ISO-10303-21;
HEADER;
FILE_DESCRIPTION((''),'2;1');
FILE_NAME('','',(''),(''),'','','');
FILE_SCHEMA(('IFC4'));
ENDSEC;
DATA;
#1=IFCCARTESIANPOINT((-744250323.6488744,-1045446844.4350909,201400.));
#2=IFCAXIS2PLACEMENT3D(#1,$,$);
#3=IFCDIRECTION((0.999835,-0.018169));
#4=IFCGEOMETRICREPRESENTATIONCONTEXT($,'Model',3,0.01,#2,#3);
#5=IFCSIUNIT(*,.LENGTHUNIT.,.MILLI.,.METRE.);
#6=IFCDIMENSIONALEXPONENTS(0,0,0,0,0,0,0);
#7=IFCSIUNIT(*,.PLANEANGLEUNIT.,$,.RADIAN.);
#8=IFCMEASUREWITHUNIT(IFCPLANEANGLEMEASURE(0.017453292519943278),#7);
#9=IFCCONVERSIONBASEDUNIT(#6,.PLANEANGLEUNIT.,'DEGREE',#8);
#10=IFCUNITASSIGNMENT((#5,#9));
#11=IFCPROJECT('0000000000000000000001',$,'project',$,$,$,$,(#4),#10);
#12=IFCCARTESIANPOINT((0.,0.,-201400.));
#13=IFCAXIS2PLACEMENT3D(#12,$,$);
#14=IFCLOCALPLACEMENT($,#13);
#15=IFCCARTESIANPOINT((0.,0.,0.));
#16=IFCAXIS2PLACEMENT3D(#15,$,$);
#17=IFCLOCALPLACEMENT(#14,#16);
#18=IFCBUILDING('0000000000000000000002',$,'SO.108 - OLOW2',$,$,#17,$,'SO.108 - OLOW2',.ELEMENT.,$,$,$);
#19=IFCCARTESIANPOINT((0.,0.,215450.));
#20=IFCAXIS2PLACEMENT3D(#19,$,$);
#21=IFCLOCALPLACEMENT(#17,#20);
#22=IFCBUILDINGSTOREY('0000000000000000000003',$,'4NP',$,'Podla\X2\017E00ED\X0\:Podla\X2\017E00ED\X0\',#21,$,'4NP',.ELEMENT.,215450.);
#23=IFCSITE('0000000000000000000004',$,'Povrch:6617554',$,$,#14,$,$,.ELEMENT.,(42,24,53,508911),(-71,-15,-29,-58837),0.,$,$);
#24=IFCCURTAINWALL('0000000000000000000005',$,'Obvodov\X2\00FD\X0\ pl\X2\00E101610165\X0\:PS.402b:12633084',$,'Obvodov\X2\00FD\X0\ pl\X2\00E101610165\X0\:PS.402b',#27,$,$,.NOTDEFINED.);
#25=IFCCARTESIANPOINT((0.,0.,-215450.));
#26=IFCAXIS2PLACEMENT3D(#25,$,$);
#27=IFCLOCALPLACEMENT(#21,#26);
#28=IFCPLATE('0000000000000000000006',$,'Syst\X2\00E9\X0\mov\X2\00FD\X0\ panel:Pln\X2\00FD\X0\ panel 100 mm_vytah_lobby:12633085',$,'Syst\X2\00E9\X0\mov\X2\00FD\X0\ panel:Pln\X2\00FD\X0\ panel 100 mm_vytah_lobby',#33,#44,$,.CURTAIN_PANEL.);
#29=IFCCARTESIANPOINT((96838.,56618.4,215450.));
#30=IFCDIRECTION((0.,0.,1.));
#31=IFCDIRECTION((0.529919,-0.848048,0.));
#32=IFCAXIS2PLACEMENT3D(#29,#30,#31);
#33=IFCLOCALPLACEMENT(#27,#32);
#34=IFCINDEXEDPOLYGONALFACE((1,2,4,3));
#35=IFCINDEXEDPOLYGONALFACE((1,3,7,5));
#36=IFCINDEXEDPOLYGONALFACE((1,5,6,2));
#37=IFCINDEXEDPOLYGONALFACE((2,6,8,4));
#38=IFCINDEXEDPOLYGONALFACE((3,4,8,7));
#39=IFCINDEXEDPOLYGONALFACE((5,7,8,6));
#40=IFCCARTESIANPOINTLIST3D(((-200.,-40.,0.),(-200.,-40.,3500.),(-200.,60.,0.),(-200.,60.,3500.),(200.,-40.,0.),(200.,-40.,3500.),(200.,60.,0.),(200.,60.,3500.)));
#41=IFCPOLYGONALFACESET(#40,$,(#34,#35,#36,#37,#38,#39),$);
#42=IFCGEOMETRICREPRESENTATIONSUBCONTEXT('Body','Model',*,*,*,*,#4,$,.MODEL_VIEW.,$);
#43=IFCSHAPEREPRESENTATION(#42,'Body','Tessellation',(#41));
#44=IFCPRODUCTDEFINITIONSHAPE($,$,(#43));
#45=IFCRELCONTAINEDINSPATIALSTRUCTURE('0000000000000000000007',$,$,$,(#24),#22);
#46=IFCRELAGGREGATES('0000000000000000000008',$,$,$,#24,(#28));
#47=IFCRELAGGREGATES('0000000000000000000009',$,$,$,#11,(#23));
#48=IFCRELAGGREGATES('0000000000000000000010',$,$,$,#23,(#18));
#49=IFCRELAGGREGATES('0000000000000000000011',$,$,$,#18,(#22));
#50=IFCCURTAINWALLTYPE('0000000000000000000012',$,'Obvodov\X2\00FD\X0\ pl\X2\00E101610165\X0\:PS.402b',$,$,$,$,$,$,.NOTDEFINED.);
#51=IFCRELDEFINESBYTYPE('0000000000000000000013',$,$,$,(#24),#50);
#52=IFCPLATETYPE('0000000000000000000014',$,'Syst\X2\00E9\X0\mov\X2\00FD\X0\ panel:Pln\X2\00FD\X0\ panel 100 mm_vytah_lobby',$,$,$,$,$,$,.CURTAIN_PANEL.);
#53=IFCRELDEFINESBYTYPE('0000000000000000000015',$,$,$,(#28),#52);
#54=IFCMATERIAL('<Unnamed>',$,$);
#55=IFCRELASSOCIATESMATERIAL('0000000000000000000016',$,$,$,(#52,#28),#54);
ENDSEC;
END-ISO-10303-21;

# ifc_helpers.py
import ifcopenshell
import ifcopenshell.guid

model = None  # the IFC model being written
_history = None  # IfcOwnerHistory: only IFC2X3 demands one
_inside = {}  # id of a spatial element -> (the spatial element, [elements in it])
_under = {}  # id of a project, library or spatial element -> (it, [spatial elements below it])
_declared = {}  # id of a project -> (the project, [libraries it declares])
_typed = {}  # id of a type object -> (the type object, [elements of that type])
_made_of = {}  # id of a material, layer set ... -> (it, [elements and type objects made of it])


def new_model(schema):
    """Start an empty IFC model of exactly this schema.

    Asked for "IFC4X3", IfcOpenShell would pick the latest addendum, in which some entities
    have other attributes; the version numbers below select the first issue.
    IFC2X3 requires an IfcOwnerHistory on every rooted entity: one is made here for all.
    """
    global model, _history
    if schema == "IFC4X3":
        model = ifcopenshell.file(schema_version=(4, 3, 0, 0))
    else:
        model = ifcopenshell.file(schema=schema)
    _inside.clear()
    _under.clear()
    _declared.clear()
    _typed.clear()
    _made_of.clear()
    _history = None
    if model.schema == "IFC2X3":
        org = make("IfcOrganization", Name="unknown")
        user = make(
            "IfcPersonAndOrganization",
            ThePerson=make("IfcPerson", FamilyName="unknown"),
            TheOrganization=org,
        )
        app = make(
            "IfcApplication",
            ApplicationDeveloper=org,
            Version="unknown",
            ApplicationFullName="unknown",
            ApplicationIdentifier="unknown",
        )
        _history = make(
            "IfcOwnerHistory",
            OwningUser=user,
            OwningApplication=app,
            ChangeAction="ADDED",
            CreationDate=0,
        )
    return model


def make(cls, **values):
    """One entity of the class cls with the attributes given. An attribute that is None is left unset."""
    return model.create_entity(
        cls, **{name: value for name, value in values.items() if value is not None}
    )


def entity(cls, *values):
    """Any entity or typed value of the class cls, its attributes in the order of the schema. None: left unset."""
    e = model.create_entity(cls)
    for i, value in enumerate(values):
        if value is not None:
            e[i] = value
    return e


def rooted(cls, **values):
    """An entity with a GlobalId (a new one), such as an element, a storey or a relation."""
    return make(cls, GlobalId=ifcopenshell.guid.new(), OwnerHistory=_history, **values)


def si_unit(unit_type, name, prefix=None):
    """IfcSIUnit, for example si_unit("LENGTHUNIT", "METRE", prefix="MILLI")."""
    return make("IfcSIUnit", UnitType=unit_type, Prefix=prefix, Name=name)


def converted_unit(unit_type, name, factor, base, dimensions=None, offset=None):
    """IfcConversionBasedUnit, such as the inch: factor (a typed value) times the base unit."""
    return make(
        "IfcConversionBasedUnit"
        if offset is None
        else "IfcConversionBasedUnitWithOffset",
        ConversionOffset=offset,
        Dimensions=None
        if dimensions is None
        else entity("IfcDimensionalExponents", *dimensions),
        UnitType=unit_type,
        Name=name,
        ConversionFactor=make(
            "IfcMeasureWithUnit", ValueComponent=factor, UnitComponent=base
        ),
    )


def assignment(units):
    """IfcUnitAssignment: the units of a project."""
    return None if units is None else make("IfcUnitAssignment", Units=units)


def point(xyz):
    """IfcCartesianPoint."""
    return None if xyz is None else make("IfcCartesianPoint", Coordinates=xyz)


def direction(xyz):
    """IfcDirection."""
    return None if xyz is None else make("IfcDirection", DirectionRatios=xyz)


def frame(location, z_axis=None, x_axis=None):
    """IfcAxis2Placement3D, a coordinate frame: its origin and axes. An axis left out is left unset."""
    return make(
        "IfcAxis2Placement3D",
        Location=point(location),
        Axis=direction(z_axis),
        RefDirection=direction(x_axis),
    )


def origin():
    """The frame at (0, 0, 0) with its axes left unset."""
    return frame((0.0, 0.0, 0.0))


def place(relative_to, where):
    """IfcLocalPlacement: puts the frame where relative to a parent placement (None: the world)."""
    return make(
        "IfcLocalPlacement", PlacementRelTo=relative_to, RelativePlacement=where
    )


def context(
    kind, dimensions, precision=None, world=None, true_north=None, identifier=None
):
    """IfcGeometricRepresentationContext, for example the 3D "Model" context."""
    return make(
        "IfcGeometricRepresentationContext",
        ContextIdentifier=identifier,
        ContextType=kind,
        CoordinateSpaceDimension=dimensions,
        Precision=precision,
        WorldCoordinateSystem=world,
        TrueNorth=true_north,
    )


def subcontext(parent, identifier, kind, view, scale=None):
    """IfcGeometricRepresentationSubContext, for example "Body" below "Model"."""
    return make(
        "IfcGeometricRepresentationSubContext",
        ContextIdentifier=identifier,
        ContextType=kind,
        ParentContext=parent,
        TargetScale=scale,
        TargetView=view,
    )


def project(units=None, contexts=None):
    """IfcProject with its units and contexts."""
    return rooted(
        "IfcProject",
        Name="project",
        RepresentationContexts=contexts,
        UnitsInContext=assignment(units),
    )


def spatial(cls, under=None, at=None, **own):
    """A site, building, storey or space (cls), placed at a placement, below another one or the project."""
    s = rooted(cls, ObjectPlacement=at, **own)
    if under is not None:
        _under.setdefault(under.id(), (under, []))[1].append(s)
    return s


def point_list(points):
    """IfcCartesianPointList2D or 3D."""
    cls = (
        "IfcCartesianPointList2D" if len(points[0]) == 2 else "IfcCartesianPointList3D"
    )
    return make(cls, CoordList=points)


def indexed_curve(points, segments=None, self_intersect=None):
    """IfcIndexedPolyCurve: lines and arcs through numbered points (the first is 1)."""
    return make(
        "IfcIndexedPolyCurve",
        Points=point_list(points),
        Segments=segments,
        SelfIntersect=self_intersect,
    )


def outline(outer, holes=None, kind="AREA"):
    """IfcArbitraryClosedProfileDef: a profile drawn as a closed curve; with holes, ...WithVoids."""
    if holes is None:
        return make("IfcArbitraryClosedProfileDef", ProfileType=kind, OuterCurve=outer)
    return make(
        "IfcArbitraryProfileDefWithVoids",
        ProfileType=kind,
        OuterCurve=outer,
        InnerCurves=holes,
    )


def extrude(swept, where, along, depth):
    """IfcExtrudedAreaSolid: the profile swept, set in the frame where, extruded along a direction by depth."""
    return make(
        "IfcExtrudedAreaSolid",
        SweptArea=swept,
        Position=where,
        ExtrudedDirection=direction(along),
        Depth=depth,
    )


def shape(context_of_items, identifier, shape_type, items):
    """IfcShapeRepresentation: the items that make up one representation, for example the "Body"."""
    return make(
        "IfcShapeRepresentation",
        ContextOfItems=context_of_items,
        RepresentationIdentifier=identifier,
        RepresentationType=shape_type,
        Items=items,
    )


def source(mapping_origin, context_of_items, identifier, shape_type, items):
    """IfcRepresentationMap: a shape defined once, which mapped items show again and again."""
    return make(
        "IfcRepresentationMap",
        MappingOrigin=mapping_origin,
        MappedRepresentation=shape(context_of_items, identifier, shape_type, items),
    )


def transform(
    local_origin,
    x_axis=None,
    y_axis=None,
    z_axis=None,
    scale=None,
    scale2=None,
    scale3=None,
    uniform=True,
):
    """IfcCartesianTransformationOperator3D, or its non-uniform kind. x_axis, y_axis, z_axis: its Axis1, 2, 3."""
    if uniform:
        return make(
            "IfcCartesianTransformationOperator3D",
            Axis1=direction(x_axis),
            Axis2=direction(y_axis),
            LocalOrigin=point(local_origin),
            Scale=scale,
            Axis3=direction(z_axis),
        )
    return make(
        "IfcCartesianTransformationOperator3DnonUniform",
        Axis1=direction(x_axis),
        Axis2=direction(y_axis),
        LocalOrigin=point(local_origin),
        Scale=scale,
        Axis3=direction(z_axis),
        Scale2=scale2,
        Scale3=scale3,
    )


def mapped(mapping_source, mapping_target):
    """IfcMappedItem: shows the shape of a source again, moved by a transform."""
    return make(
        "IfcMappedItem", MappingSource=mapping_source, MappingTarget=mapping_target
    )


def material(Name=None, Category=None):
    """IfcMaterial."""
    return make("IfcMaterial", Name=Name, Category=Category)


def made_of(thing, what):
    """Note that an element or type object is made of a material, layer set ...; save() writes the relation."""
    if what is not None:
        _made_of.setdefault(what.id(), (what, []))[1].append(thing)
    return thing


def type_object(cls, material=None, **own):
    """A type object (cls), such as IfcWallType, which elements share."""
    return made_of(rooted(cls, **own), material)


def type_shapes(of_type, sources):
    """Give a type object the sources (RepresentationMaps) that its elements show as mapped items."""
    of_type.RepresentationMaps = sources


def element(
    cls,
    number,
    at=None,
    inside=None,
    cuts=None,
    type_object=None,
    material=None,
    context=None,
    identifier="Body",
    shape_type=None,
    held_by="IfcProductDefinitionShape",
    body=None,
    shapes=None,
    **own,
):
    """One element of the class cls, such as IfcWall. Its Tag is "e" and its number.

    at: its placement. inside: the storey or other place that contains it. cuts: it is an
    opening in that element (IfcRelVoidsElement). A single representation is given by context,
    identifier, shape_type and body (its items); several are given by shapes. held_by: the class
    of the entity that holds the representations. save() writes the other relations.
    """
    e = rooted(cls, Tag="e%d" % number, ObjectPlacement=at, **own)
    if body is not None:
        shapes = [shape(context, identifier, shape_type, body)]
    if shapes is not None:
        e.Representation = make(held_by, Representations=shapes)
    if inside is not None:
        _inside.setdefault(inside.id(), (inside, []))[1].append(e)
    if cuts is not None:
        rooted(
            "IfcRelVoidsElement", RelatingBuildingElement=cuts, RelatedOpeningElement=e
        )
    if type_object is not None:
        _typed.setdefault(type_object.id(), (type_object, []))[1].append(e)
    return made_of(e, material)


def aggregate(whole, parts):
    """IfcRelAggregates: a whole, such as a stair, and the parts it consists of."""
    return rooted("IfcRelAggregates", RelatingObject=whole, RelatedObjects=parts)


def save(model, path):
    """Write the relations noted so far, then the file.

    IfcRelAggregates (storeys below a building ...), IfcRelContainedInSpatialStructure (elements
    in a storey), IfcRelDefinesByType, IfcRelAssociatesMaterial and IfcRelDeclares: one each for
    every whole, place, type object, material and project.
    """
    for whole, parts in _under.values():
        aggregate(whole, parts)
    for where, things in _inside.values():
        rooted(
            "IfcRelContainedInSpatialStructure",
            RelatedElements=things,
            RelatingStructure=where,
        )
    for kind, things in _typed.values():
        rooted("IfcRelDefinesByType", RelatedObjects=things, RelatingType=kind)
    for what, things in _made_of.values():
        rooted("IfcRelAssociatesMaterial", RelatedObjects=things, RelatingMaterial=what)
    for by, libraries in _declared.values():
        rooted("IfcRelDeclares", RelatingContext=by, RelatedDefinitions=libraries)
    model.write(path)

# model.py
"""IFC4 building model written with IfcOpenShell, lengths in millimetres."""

from ifc_helpers import new_model, entity, si_unit, converted_unit, direction, frame, origin, place, context, subcontext, project, spatial, indexed_curve, outline, extrude, source, transform, mapped, material, type_object, type_shapes, element, aggregate, save


model = new_model("IFC4")

# Units and contexts
model_context = context("Model", 3, precision=0.01, world=frame((-744250323.6488744, -1045446844.4350909, 201400.0)), true_north=direction((0.999835, -0.018169)))
body_context = subcontext(model_context, "Body", "Model", "MODEL_VIEW")
ifc_project = project(units=[si_unit("LENGTHUNIT", "METRE", prefix="MILLI"), converted_unit("PLANEANGLEUNIT", "DEGREE", entity("IfcPlaneAngleMeasure", 0.017453292519943278), si_unit("PLANEANGLEUNIT", "RADIAN"), dimensions=[0, 0, 0, 0, 0, 0, 0])], contexts=[model_context])

# Site, building, storey
site_placement = place(None, frame((0.0, 0.0, -201400.0)))
site = spatial("IfcSite", under=ifc_project, at=site_placement, Name="Povrch:6617554", CompositionType="ELEMENT", RefLatitude=(42, 24, 53, 508911), RefLongitude=(-71, -15, -29, -58837), RefElevation=0.0)
building_placement = place(site_placement, origin())
building = spatial("IfcBuilding", under=site, at=building_placement, Name="SO.108 - OLOW2", LongName="SO.108 - OLOW2", CompositionType="ELEMENT")
storey_placement = place(building_placement, frame((0.0, 0.0, 215450.0)))
storey = spatial("IfcBuildingStorey", under=building, at=storey_placement, Name="4NP", ObjectType="Podlaží:Podlaží", LongName="4NP", CompositionType="ELEMENT", Elevation=215450.0)

# Shared definitions
ifc_material_1 = material(Name="<Unnamed>")

# Curtain wall
curtain_wall_type_1 = type_object("IfcCurtainWallType", Name="Obvodový plášť:PS.402b", PredefinedType="NOTDEFINED")
curtain_wall_1_placement = place(storey_placement, frame((0.0, 0.0, -215450.0)))
curtain_wall_1 = element("IfcCurtainWall", 1, at=curtain_wall_1_placement, inside=storey, type_object=curtain_wall_type_1, Name="Obvodový plášť:PS.402b:12633084", ObjectType="Obvodový plášť:PS.402b", PredefinedType="NOTDEFINED")

# Plate
plate_type_1 = type_object("IfcPlateType", Name="Systémový panel:Plný panel 100 mm_vytah_lobby", PredefinedType="CURTAIN_PANEL", material=ifc_material_1)
shared_shape_1 = source(origin(), body_context, "Body", "SweptSolid", [
    extrude(outline(indexed_curve([(-50.0, -200.0), (50.0, -200.0), (50.0, 200.0), (-50.0, 200.0), (-50.0, -200.0)], self_intersect=False)), frame((0.0, 10.0, 0.0), z_axis=(0.0, 0.0, 1.0), x_axis=(0.0, 1.0, 0.0)), (0.0, 0.0, 1.0), 3500.0),
])
type_shapes(plate_type_1, [shared_shape_1])
plate_1_placement = place(curtain_wall_1_placement, frame((96838.0, 56618.4, 215450.0), z_axis=(0.0, 0.0, 1.0), x_axis=(0.529919, -0.848048, 0.0)))
plate_1 = element("IfcPlate", 2, at=plate_1_placement, type_object=plate_type_1, material=ifc_material_1, Name="Systémový panel:Plný panel 100 mm_vytah_lobby:12633085", ObjectType="Systémový panel:Plný panel 100 mm_vytah_lobby", PredefinedType="CURTAIN_PANEL", context=body_context, shape_type="MappedRepresentation", body=[
    mapped(shared_shape_1, transform((0.0, 0.0, 0.0), scale=1.0)),
])
aggregate(curtain_wall_1, [plate_1])

save(model, "model.ifc")
